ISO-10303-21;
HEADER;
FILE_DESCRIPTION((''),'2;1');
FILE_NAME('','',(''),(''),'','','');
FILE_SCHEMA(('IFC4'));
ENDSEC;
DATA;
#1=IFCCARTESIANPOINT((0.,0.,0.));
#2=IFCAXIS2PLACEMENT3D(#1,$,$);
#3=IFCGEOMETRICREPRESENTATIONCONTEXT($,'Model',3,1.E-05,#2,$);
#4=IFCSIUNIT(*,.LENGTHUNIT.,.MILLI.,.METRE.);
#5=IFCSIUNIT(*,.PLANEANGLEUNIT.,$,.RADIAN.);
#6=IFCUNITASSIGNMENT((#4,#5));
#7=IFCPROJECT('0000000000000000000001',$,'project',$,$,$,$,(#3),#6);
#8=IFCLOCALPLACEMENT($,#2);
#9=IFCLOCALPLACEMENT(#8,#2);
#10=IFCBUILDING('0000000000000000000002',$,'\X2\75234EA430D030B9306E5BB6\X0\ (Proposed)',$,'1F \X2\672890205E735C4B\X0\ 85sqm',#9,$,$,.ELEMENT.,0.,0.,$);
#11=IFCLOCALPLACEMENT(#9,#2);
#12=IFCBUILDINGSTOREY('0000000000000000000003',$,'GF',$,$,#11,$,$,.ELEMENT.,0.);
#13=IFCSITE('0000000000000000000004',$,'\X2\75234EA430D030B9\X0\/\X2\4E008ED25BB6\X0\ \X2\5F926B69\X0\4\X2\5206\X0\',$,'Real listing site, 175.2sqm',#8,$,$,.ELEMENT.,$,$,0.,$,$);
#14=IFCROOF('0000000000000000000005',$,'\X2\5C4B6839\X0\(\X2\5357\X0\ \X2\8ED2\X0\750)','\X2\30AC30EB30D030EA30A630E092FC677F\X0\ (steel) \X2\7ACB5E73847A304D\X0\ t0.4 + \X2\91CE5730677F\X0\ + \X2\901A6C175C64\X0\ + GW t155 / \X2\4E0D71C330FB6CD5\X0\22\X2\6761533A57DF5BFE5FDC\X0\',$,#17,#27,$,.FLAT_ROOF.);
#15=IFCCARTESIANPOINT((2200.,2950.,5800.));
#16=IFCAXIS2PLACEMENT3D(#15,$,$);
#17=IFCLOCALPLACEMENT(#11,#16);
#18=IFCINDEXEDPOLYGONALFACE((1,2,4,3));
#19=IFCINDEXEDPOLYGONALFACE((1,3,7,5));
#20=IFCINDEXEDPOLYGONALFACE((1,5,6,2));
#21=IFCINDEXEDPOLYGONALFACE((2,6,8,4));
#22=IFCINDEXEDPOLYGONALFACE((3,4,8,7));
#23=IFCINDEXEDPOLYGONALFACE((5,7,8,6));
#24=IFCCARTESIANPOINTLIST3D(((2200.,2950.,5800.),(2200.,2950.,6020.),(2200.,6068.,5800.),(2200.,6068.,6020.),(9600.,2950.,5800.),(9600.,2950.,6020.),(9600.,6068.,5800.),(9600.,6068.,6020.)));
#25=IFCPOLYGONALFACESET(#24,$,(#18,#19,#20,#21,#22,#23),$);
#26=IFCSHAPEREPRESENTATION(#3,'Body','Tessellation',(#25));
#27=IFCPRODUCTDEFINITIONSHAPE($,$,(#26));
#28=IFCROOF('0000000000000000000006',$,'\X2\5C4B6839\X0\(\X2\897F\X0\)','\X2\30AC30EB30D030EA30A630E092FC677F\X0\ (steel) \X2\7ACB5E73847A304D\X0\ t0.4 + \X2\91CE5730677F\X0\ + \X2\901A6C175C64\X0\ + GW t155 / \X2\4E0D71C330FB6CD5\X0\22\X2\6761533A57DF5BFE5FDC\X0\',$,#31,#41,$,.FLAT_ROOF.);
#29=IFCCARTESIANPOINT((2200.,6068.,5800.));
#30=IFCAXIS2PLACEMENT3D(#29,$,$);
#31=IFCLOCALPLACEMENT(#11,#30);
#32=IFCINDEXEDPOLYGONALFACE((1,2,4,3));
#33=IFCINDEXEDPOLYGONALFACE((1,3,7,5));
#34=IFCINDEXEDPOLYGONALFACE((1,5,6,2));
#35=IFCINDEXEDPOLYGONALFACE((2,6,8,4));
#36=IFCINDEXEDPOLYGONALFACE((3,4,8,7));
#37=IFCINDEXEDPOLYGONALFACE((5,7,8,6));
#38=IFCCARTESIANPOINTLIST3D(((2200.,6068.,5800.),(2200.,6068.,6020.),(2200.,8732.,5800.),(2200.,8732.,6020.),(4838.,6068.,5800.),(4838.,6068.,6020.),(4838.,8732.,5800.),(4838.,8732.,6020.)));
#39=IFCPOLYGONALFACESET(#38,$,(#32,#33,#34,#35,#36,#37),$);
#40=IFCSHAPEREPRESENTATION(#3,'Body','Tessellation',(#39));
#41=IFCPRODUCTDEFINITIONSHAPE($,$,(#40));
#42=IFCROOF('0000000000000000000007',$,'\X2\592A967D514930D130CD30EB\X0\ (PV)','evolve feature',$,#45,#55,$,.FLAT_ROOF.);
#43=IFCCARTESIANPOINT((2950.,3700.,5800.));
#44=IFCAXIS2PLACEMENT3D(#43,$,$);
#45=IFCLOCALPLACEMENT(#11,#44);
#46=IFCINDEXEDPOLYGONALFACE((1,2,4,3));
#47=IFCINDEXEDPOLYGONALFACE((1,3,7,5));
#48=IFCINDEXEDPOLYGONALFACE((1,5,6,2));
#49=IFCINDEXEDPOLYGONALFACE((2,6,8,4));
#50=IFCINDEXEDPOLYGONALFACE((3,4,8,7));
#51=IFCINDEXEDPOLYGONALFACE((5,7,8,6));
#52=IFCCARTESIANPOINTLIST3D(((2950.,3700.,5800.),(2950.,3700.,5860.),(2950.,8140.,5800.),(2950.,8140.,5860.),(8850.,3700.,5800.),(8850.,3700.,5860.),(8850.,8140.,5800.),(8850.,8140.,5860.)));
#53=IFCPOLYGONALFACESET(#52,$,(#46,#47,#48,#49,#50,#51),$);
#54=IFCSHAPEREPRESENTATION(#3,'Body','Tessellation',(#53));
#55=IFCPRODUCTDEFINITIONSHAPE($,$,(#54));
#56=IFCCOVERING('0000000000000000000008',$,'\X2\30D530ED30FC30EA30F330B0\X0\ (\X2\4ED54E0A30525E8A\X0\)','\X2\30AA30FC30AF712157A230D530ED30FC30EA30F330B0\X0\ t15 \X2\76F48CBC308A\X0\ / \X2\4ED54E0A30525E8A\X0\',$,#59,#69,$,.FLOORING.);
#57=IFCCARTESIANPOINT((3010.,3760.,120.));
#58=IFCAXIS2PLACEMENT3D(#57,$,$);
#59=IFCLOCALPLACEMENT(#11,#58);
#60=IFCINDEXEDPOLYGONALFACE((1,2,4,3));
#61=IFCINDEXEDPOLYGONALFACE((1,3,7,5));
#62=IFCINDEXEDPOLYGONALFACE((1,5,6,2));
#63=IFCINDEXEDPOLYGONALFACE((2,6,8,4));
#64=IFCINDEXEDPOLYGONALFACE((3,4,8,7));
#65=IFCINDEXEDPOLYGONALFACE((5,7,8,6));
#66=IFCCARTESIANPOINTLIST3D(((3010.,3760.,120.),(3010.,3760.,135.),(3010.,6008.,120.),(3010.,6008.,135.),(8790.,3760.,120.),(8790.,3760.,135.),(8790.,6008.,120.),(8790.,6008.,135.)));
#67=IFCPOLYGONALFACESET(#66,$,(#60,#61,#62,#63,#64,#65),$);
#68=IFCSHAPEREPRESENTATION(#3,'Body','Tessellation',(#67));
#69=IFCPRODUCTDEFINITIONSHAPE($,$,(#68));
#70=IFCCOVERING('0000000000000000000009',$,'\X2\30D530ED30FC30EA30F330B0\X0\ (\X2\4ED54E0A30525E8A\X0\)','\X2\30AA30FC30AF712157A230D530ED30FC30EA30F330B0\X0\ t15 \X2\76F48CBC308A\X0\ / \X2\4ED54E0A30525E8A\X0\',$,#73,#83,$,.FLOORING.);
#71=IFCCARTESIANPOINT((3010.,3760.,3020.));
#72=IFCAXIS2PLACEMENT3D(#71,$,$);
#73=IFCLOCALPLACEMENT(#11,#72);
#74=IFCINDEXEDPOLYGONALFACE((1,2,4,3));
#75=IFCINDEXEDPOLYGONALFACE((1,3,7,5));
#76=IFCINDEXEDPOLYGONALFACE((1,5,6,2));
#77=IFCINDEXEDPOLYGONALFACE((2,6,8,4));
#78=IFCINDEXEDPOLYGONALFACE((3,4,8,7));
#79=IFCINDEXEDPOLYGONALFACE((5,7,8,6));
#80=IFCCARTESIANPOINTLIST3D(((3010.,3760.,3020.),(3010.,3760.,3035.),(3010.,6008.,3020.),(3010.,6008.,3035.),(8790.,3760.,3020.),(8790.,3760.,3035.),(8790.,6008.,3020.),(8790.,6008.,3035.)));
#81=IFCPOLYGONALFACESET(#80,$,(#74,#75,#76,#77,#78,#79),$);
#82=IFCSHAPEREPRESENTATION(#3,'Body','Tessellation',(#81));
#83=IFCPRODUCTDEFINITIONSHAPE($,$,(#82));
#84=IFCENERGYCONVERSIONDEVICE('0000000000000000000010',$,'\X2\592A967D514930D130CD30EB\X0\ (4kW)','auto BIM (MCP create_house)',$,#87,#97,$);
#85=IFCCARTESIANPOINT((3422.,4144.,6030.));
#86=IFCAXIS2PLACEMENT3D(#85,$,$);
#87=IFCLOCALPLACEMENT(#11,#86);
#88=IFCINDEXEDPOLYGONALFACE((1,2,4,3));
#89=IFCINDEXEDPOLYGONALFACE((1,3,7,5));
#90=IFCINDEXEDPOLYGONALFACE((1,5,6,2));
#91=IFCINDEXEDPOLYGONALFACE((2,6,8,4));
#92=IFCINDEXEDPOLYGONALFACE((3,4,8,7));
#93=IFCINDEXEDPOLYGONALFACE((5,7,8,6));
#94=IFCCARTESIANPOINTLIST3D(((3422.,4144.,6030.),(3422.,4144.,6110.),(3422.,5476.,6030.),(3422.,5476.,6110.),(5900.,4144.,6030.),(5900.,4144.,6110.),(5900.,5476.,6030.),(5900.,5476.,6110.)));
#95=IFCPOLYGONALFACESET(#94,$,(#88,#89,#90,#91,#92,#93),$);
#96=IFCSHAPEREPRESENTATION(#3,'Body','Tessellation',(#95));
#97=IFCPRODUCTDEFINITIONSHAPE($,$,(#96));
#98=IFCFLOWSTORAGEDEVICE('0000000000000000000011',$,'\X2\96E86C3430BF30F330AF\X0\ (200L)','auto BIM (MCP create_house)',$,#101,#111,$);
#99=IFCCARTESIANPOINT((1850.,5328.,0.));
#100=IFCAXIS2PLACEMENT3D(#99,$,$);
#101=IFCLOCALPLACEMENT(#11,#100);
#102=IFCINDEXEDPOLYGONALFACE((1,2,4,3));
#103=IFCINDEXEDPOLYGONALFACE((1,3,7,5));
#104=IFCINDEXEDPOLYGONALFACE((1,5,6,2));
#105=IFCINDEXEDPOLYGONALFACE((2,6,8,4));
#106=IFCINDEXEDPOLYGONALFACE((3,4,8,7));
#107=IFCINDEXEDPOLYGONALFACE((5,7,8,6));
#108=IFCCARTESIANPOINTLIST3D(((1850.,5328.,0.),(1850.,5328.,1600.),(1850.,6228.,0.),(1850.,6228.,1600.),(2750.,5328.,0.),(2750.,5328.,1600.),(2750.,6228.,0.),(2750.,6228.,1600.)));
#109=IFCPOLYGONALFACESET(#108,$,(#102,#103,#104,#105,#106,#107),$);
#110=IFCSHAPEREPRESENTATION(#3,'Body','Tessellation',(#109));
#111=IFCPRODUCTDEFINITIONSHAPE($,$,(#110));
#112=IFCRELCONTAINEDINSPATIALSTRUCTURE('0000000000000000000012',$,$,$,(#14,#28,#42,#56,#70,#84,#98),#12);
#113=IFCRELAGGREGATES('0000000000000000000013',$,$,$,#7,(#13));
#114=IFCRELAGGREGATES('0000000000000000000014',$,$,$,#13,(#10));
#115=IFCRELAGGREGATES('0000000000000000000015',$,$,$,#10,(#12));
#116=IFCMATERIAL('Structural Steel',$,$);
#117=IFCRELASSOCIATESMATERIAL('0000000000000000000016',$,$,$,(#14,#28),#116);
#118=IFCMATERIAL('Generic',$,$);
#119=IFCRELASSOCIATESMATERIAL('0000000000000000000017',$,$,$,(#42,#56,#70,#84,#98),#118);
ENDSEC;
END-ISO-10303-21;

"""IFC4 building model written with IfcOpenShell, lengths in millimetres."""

from ifc_helpers import new_model, si_unit, frame, frame_2d, origin, place, context, project, spatial, rectangle, extrude, material, element, save


model = new_model("IFC4")

# Units and contexts
model_context = context("Model", 3, precision=1e-05, world=origin())
ifc_project = project(units=[si_unit("LENGTHUNIT", "METRE", prefix="MILLI"), si_unit("PLANEANGLEUNIT", "RADIAN")], contexts=[model_context])

# Site, building, storey
site_placement = place(None, origin())
site = spatial("IfcSite", under=ifc_project, at=site_placement, Name="産交バス/一軒家 徒歩4分", ObjectType="Real listing site, 175.2sqm", CompositionType="ELEMENT", RefElevation=0.0)
building_placement = place(site_placement, origin())
building = spatial("IfcBuilding", under=site, at=building_placement, Name="産交バスの家 (Proposed)", ObjectType="1F 木造平屋 85sqm", CompositionType="ELEMENT", ElevationOfRefHeight=0.0, ElevationOfTerrain=0.0)
storey_placement = place(building_placement, origin())
storey = spatial("IfcBuildingStorey", under=building, at=storey_placement, Name="GF", CompositionType="ELEMENT", Elevation=0.0)

# Shared definitions
ifc_material_1 = material(Name="Generic")

# Roofs
ifc_material_2 = material(Name="Structural Steel")
roof_1_placement = place(storey_placement, frame((2200.0, 2950.0, 5800.0)))
element("IfcRoof", 1, at=roof_1_placement, inside=storey, material=ifc_material_2, Name="屋根(南 軒750)", Description="ガルバリウム鋼板 (steel) 立平葺き t0.4 + 野地板 + 通気層 + GW t155 / 不燃・法22条区域対応", PredefinedType="FLAT_ROOF", context=model_context, shape_type="SweptSolid", body=[
    extrude(rectangle(XDim=7400.0, YDim=3118.0, at=frame_2d((3700.0, 1559.0))), frame((2200.0, 2950.0, 5800.0)), (0.0, 0.0, 1.0), 220.0),
])
roof_2_placement = place(storey_placement, frame((2200.0, 6068.0, 5800.0)))
element("IfcRoof", 2, at=roof_2_placement, inside=storey, material=ifc_material_2, Name="屋根(西)", Description="ガルバリウム鋼板 (steel) 立平葺き t0.4 + 野地板 + 通気層 + GW t155 / 不燃・法22条区域対応", PredefinedType="FLAT_ROOF", context=model_context, shape_type="SweptSolid", body=[
    extrude(rectangle(XDim=2638.0, YDim=2664.0, at=frame_2d((1319.0, 1332.0))), frame((2200.0, 6068.0, 5800.0)), (0.0, 0.0, 1.0), 220.0),
])
roof_3_placement = place(storey_placement, frame((2950.0, 3700.0, 5800.0)))
element("IfcRoof", 3, at=roof_3_placement, inside=storey, material=ifc_material_1, Name="太陽光パネル (PV)", Description="evolve feature", PredefinedType="FLAT_ROOF", context=model_context, shape_type="SweptSolid", body=[
    extrude(rectangle(XDim=5900.0, YDim=4440.0, at=frame_2d((2950.0, 2220.0))), frame((2950.0, 3700.0, 5800.0)), (0.0, 0.0, 1.0), 60.0),
])

# Coverings
covering_1_placement = place(storey_placement, frame((3010.0, 3760.0, 120.0)))
element("IfcCovering", 4, at=covering_1_placement, inside=storey, material=ifc_material_1, Name="フローリング (仕上げ床)", Description="オーク無垢フローリング t15 直貼り / 仕上げ床", PredefinedType="FLOORING", context=model_context, shape_type="SweptSolid", body=[
    extrude(rectangle(XDim=5780.0, YDim=2248.0, at=frame_2d((2890.0, 1124.0))), frame((3010.0, 3760.0, 120.0)), (0.0, 0.0, 1.0), 15.0),
])
covering_2_placement = place(storey_placement, frame((3010.0, 3760.0, 3020.0)))
element("IfcCovering", 5, at=covering_2_placement, inside=storey, material=ifc_material_1, Name="フローリング (仕上げ床)", Description="オーク無垢フローリング t15 直貼り / 仕上げ床", PredefinedType="FLOORING", context=model_context, shape_type="SweptSolid", body=[
    extrude(rectangle(XDim=5780.0, YDim=2248.0, at=frame_2d((2890.0, 1124.0))), frame((3010.0, 3760.0, 3020.0)), (0.0, 0.0, 1.0), 15.0),
])

# Energy conversion device
energy_conversion_device_placement = place(storey_placement, frame((3422.0, 4144.0, 6030.0)))
element("IfcEnergyConversionDevice", 6, at=energy_conversion_device_placement, inside=storey, material=ifc_material_1, Name="太陽光パネル (4kW)", Description="auto BIM (MCP create_house)", context=model_context, shape_type="SweptSolid", body=[
    extrude(rectangle(XDim=2478.0, YDim=1332.0, at=frame_2d((1239.0, 666.0))), frame((3422.0, 4144.0, 6030.0)), (0.0, 0.0, 1.0), 80.0),
])

# Flow storage device
flow_storage_device_placement = place(storey_placement, frame((1850.0, 5328.0, 0.0)))
element("IfcFlowStorageDevice", 7, at=flow_storage_device_placement, inside=storey, material=ifc_material_1, Name="雨水タンク (200L)", Description="auto BIM (MCP create_house)", context=model_context, shape_type="SweptSolid", body=[
    extrude(rectangle(XDim=900.0, YDim=900.0, at=frame_2d((450.0, 450.0))), frame((1850.0, 5328.0, 0.0)), (0.0, 0.0, 1.0), 1600.0),
])

save(model, "model.ifc")
